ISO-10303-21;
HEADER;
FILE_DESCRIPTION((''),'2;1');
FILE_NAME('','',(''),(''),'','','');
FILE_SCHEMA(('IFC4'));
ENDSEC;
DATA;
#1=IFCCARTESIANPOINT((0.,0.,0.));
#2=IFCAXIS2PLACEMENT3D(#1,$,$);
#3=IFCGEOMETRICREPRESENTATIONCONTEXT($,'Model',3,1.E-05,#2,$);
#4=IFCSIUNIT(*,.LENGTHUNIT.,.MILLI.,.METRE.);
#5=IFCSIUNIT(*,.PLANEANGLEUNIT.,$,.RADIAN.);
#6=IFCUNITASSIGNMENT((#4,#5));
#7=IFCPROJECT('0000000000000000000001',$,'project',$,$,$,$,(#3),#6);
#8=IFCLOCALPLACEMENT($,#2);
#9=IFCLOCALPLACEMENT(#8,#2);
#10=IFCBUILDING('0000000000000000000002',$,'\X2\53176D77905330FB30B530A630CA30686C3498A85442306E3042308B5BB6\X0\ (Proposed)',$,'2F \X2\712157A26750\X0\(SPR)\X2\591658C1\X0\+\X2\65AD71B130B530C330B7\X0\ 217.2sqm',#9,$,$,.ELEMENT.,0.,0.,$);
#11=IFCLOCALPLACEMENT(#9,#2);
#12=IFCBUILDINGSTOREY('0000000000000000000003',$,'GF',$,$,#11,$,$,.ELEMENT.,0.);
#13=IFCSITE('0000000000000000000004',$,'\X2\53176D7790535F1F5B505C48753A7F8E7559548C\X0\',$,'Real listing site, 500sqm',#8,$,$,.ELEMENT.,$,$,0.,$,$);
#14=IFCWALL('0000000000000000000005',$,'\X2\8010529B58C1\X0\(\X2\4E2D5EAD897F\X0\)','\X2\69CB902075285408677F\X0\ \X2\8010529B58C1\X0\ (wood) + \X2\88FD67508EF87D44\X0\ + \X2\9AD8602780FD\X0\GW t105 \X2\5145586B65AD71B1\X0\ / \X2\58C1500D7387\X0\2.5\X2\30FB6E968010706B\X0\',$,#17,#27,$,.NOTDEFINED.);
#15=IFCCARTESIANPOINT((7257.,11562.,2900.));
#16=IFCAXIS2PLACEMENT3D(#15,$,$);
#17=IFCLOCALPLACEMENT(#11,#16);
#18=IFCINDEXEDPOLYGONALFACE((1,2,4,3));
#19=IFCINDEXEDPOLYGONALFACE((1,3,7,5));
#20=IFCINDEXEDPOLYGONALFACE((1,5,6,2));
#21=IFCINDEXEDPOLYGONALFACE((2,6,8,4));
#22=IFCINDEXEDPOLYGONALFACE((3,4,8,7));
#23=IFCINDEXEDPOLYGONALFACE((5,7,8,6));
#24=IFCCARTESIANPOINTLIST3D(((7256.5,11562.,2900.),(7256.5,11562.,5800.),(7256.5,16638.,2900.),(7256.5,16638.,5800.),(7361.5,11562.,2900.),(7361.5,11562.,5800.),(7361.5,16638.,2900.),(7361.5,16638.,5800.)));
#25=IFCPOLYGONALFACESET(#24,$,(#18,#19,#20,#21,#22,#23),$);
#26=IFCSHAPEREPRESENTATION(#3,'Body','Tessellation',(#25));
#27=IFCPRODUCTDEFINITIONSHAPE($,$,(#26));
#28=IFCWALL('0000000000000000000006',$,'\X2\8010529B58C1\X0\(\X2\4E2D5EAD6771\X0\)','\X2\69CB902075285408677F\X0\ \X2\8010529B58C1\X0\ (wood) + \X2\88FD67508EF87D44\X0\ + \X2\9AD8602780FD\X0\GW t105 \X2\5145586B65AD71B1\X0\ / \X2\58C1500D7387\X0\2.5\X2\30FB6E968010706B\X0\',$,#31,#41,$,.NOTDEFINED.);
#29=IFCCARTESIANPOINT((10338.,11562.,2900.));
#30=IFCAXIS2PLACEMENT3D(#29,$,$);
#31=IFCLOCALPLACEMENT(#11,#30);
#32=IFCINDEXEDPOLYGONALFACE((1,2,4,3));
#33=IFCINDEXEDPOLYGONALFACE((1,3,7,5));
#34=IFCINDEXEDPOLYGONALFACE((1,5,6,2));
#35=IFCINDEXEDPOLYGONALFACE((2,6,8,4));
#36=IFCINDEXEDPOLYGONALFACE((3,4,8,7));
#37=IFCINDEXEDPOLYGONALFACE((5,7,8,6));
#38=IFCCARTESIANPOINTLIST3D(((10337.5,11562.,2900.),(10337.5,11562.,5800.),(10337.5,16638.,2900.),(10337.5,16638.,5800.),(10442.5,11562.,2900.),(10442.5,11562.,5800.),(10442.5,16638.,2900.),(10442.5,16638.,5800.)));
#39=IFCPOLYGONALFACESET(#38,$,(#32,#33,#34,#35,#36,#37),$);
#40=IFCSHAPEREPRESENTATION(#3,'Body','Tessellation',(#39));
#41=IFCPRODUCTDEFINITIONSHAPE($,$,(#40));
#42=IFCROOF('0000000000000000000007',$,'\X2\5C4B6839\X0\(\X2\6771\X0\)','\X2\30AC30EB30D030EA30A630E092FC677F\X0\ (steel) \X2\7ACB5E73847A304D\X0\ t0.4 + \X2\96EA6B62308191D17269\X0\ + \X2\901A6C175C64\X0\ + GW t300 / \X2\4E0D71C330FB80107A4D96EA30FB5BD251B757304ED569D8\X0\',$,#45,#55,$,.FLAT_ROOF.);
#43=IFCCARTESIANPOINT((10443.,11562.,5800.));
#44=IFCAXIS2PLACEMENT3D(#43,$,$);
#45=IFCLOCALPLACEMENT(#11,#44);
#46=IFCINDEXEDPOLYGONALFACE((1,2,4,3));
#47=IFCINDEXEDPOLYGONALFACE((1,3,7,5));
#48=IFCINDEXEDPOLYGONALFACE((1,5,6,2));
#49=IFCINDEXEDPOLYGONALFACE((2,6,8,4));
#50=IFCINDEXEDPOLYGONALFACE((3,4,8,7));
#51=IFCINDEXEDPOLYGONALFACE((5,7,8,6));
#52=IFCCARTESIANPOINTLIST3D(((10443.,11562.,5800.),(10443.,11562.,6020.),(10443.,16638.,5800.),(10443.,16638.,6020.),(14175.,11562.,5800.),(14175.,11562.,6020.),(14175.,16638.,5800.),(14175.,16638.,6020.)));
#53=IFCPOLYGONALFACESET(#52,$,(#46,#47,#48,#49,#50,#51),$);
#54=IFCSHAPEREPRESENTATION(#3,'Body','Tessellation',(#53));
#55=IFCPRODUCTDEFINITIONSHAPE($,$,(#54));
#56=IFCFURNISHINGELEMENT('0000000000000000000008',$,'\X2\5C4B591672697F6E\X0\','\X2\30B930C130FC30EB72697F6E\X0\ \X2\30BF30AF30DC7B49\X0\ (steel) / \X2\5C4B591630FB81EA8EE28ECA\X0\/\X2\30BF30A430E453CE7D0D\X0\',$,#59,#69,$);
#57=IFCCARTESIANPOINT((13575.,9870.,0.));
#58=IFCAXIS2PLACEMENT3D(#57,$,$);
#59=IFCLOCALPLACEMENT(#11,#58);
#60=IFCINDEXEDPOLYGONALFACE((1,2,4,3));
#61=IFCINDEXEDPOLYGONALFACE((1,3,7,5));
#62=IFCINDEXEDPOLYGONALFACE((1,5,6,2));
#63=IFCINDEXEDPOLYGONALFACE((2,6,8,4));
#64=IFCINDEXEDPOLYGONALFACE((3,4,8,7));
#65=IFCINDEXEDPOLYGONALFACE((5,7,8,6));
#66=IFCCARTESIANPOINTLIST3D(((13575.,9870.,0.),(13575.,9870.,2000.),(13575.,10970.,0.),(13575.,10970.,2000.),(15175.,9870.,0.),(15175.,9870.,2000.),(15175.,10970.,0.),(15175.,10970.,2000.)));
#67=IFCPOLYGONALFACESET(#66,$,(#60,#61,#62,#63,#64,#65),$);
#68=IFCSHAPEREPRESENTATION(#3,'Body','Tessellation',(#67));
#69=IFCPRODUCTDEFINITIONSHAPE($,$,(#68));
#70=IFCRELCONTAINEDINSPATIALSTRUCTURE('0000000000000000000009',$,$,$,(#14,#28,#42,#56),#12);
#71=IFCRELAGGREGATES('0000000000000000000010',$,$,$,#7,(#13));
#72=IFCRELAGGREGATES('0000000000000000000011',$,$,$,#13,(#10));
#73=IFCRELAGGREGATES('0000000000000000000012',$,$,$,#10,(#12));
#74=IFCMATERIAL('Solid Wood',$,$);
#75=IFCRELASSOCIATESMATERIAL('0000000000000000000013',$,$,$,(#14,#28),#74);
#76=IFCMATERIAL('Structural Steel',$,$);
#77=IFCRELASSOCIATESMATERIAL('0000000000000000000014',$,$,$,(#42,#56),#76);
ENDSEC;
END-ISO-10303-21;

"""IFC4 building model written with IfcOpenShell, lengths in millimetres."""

from ifc_helpers import new_model, si_unit, frame, frame_2d, origin, place, context, project, spatial, rectangle, extrude, material, element, save


model = new_model("IFC4")

# Units and contexts
model_context = context("Model", 3, precision=1e-05, world=origin())
ifc_project = project(units=[si_unit("LENGTHUNIT", "METRE", prefix="MILLI"), si_unit("PLANEANGLEUNIT", "RADIAN")], contexts=[model_context])

# Site, building, storey
site_placement = place(None, origin())
site = spatial("IfcSite", under=ifc_project, at=site_placement, Name="北海道弟子屈町美留和", ObjectType="Real listing site, 500sqm", CompositionType="ELEMENT", RefElevation=0.0)
building_placement = place(site_placement, origin())
building = spatial("IfcBuilding", under=site, at=building_placement, Name="北海道・サウナと水風呂のある家 (Proposed)", ObjectType="2F 無垢材(SPR)外壁+断熱サッシ 217.2sqm", CompositionType="ELEMENT", ElevationOfRefHeight=0.0, ElevationOfTerrain=0.0)
storey_placement = place(building_placement, origin())
storey = spatial("IfcBuildingStorey", under=building, at=storey_placement, Name="GF", CompositionType="ELEMENT", Elevation=0.0)

# Shared definitions
ifc_material_1 = material(Name="Solid Wood")

# Walls
wall_1_placement = place(storey_placement, frame((7257.0, 11562.0, 2900.0)))
element("IfcWall", 1, at=wall_1_placement, inside=storey, material=ifc_material_1, Name="耐力壁(中庭西)", Description="構造用合板 耐力壁 (wood) + 製材軸組 + 高性能GW t105 充填断熱 / 壁倍率2.5・準耐火", PredefinedType="NOTDEFINED", context=model_context, shape_type="SweptSolid", body=[
    extrude(rectangle(XDim=105.0, YDim=5076.0, at=frame_2d((52.0, 2538.0))), frame((7257.0, 11562.0, 2900.0)), (0.0, 0.0, 1.0), 2900.0),
])
wall_2_placement = place(storey_placement, frame((10338.0, 11562.0, 2900.0)))
element("IfcWall", 2, at=wall_2_placement, inside=storey, material=ifc_material_1, Name="耐力壁(中庭東)", Description="構造用合板 耐力壁 (wood) + 製材軸組 + 高性能GW t105 充填断熱 / 壁倍率2.5・準耐火", PredefinedType="NOTDEFINED", context=model_context, shape_type="SweptSolid", body=[
    extrude(rectangle(XDim=105.0, YDim=5076.0, at=frame_2d((52.0, 2538.0))), frame((10338.0, 11562.0, 2900.0)), (0.0, 0.0, 1.0), 2900.0),
])

# Roof
ifc_material_2 = material(Name="Structural Steel")
for number, where, name in (
    (3, (10443.0, 11562.0, 5800.0), "屋根(東)"),
):
    element("IfcRoof", number, at=place(storey_placement, frame(where)), inside=storey, material=ifc_material_2, Name=name, Description="ガルバリウム鋼板 (steel) 立平葺き t0.4 + 雪止め金物 + 通気層 + GW t300 / 不燃・耐積雪・寒冷地仕様", PredefinedType="FLAT_ROOF", context=model_context, shape_type="SweptSolid", body=[
        extrude(rectangle(XDim=3732.0, YDim=5076.0, at=frame_2d((1866.0, 2538.0))), frame((10443.0, 11562.0, 5800.0)), (0.0, 0.0, 1.0), 220.0),
    ])

# Furnishing element
furnishing_placement = place(storey_placement, frame((13575.0, 9870.0, 0.0)))
element("IfcFurnishingElement", 4, at=furnishing_placement, inside=storey, material=ifc_material_2, Name="屋外物置", Description="スチール物置 タクボ等 (steel) / 屋外・自転車/タイヤ収納", context=model_context, shape_type="SweptSolid", body=[
    extrude(rectangle(XDim=1600.0, YDim=1100.0, at=frame_2d((800.0, 550.0))), frame((13575.0, 9870.0, 0.0)), (0.0, 0.0, 1.0), 2000.0),
])

save(model, "model.ifc")
